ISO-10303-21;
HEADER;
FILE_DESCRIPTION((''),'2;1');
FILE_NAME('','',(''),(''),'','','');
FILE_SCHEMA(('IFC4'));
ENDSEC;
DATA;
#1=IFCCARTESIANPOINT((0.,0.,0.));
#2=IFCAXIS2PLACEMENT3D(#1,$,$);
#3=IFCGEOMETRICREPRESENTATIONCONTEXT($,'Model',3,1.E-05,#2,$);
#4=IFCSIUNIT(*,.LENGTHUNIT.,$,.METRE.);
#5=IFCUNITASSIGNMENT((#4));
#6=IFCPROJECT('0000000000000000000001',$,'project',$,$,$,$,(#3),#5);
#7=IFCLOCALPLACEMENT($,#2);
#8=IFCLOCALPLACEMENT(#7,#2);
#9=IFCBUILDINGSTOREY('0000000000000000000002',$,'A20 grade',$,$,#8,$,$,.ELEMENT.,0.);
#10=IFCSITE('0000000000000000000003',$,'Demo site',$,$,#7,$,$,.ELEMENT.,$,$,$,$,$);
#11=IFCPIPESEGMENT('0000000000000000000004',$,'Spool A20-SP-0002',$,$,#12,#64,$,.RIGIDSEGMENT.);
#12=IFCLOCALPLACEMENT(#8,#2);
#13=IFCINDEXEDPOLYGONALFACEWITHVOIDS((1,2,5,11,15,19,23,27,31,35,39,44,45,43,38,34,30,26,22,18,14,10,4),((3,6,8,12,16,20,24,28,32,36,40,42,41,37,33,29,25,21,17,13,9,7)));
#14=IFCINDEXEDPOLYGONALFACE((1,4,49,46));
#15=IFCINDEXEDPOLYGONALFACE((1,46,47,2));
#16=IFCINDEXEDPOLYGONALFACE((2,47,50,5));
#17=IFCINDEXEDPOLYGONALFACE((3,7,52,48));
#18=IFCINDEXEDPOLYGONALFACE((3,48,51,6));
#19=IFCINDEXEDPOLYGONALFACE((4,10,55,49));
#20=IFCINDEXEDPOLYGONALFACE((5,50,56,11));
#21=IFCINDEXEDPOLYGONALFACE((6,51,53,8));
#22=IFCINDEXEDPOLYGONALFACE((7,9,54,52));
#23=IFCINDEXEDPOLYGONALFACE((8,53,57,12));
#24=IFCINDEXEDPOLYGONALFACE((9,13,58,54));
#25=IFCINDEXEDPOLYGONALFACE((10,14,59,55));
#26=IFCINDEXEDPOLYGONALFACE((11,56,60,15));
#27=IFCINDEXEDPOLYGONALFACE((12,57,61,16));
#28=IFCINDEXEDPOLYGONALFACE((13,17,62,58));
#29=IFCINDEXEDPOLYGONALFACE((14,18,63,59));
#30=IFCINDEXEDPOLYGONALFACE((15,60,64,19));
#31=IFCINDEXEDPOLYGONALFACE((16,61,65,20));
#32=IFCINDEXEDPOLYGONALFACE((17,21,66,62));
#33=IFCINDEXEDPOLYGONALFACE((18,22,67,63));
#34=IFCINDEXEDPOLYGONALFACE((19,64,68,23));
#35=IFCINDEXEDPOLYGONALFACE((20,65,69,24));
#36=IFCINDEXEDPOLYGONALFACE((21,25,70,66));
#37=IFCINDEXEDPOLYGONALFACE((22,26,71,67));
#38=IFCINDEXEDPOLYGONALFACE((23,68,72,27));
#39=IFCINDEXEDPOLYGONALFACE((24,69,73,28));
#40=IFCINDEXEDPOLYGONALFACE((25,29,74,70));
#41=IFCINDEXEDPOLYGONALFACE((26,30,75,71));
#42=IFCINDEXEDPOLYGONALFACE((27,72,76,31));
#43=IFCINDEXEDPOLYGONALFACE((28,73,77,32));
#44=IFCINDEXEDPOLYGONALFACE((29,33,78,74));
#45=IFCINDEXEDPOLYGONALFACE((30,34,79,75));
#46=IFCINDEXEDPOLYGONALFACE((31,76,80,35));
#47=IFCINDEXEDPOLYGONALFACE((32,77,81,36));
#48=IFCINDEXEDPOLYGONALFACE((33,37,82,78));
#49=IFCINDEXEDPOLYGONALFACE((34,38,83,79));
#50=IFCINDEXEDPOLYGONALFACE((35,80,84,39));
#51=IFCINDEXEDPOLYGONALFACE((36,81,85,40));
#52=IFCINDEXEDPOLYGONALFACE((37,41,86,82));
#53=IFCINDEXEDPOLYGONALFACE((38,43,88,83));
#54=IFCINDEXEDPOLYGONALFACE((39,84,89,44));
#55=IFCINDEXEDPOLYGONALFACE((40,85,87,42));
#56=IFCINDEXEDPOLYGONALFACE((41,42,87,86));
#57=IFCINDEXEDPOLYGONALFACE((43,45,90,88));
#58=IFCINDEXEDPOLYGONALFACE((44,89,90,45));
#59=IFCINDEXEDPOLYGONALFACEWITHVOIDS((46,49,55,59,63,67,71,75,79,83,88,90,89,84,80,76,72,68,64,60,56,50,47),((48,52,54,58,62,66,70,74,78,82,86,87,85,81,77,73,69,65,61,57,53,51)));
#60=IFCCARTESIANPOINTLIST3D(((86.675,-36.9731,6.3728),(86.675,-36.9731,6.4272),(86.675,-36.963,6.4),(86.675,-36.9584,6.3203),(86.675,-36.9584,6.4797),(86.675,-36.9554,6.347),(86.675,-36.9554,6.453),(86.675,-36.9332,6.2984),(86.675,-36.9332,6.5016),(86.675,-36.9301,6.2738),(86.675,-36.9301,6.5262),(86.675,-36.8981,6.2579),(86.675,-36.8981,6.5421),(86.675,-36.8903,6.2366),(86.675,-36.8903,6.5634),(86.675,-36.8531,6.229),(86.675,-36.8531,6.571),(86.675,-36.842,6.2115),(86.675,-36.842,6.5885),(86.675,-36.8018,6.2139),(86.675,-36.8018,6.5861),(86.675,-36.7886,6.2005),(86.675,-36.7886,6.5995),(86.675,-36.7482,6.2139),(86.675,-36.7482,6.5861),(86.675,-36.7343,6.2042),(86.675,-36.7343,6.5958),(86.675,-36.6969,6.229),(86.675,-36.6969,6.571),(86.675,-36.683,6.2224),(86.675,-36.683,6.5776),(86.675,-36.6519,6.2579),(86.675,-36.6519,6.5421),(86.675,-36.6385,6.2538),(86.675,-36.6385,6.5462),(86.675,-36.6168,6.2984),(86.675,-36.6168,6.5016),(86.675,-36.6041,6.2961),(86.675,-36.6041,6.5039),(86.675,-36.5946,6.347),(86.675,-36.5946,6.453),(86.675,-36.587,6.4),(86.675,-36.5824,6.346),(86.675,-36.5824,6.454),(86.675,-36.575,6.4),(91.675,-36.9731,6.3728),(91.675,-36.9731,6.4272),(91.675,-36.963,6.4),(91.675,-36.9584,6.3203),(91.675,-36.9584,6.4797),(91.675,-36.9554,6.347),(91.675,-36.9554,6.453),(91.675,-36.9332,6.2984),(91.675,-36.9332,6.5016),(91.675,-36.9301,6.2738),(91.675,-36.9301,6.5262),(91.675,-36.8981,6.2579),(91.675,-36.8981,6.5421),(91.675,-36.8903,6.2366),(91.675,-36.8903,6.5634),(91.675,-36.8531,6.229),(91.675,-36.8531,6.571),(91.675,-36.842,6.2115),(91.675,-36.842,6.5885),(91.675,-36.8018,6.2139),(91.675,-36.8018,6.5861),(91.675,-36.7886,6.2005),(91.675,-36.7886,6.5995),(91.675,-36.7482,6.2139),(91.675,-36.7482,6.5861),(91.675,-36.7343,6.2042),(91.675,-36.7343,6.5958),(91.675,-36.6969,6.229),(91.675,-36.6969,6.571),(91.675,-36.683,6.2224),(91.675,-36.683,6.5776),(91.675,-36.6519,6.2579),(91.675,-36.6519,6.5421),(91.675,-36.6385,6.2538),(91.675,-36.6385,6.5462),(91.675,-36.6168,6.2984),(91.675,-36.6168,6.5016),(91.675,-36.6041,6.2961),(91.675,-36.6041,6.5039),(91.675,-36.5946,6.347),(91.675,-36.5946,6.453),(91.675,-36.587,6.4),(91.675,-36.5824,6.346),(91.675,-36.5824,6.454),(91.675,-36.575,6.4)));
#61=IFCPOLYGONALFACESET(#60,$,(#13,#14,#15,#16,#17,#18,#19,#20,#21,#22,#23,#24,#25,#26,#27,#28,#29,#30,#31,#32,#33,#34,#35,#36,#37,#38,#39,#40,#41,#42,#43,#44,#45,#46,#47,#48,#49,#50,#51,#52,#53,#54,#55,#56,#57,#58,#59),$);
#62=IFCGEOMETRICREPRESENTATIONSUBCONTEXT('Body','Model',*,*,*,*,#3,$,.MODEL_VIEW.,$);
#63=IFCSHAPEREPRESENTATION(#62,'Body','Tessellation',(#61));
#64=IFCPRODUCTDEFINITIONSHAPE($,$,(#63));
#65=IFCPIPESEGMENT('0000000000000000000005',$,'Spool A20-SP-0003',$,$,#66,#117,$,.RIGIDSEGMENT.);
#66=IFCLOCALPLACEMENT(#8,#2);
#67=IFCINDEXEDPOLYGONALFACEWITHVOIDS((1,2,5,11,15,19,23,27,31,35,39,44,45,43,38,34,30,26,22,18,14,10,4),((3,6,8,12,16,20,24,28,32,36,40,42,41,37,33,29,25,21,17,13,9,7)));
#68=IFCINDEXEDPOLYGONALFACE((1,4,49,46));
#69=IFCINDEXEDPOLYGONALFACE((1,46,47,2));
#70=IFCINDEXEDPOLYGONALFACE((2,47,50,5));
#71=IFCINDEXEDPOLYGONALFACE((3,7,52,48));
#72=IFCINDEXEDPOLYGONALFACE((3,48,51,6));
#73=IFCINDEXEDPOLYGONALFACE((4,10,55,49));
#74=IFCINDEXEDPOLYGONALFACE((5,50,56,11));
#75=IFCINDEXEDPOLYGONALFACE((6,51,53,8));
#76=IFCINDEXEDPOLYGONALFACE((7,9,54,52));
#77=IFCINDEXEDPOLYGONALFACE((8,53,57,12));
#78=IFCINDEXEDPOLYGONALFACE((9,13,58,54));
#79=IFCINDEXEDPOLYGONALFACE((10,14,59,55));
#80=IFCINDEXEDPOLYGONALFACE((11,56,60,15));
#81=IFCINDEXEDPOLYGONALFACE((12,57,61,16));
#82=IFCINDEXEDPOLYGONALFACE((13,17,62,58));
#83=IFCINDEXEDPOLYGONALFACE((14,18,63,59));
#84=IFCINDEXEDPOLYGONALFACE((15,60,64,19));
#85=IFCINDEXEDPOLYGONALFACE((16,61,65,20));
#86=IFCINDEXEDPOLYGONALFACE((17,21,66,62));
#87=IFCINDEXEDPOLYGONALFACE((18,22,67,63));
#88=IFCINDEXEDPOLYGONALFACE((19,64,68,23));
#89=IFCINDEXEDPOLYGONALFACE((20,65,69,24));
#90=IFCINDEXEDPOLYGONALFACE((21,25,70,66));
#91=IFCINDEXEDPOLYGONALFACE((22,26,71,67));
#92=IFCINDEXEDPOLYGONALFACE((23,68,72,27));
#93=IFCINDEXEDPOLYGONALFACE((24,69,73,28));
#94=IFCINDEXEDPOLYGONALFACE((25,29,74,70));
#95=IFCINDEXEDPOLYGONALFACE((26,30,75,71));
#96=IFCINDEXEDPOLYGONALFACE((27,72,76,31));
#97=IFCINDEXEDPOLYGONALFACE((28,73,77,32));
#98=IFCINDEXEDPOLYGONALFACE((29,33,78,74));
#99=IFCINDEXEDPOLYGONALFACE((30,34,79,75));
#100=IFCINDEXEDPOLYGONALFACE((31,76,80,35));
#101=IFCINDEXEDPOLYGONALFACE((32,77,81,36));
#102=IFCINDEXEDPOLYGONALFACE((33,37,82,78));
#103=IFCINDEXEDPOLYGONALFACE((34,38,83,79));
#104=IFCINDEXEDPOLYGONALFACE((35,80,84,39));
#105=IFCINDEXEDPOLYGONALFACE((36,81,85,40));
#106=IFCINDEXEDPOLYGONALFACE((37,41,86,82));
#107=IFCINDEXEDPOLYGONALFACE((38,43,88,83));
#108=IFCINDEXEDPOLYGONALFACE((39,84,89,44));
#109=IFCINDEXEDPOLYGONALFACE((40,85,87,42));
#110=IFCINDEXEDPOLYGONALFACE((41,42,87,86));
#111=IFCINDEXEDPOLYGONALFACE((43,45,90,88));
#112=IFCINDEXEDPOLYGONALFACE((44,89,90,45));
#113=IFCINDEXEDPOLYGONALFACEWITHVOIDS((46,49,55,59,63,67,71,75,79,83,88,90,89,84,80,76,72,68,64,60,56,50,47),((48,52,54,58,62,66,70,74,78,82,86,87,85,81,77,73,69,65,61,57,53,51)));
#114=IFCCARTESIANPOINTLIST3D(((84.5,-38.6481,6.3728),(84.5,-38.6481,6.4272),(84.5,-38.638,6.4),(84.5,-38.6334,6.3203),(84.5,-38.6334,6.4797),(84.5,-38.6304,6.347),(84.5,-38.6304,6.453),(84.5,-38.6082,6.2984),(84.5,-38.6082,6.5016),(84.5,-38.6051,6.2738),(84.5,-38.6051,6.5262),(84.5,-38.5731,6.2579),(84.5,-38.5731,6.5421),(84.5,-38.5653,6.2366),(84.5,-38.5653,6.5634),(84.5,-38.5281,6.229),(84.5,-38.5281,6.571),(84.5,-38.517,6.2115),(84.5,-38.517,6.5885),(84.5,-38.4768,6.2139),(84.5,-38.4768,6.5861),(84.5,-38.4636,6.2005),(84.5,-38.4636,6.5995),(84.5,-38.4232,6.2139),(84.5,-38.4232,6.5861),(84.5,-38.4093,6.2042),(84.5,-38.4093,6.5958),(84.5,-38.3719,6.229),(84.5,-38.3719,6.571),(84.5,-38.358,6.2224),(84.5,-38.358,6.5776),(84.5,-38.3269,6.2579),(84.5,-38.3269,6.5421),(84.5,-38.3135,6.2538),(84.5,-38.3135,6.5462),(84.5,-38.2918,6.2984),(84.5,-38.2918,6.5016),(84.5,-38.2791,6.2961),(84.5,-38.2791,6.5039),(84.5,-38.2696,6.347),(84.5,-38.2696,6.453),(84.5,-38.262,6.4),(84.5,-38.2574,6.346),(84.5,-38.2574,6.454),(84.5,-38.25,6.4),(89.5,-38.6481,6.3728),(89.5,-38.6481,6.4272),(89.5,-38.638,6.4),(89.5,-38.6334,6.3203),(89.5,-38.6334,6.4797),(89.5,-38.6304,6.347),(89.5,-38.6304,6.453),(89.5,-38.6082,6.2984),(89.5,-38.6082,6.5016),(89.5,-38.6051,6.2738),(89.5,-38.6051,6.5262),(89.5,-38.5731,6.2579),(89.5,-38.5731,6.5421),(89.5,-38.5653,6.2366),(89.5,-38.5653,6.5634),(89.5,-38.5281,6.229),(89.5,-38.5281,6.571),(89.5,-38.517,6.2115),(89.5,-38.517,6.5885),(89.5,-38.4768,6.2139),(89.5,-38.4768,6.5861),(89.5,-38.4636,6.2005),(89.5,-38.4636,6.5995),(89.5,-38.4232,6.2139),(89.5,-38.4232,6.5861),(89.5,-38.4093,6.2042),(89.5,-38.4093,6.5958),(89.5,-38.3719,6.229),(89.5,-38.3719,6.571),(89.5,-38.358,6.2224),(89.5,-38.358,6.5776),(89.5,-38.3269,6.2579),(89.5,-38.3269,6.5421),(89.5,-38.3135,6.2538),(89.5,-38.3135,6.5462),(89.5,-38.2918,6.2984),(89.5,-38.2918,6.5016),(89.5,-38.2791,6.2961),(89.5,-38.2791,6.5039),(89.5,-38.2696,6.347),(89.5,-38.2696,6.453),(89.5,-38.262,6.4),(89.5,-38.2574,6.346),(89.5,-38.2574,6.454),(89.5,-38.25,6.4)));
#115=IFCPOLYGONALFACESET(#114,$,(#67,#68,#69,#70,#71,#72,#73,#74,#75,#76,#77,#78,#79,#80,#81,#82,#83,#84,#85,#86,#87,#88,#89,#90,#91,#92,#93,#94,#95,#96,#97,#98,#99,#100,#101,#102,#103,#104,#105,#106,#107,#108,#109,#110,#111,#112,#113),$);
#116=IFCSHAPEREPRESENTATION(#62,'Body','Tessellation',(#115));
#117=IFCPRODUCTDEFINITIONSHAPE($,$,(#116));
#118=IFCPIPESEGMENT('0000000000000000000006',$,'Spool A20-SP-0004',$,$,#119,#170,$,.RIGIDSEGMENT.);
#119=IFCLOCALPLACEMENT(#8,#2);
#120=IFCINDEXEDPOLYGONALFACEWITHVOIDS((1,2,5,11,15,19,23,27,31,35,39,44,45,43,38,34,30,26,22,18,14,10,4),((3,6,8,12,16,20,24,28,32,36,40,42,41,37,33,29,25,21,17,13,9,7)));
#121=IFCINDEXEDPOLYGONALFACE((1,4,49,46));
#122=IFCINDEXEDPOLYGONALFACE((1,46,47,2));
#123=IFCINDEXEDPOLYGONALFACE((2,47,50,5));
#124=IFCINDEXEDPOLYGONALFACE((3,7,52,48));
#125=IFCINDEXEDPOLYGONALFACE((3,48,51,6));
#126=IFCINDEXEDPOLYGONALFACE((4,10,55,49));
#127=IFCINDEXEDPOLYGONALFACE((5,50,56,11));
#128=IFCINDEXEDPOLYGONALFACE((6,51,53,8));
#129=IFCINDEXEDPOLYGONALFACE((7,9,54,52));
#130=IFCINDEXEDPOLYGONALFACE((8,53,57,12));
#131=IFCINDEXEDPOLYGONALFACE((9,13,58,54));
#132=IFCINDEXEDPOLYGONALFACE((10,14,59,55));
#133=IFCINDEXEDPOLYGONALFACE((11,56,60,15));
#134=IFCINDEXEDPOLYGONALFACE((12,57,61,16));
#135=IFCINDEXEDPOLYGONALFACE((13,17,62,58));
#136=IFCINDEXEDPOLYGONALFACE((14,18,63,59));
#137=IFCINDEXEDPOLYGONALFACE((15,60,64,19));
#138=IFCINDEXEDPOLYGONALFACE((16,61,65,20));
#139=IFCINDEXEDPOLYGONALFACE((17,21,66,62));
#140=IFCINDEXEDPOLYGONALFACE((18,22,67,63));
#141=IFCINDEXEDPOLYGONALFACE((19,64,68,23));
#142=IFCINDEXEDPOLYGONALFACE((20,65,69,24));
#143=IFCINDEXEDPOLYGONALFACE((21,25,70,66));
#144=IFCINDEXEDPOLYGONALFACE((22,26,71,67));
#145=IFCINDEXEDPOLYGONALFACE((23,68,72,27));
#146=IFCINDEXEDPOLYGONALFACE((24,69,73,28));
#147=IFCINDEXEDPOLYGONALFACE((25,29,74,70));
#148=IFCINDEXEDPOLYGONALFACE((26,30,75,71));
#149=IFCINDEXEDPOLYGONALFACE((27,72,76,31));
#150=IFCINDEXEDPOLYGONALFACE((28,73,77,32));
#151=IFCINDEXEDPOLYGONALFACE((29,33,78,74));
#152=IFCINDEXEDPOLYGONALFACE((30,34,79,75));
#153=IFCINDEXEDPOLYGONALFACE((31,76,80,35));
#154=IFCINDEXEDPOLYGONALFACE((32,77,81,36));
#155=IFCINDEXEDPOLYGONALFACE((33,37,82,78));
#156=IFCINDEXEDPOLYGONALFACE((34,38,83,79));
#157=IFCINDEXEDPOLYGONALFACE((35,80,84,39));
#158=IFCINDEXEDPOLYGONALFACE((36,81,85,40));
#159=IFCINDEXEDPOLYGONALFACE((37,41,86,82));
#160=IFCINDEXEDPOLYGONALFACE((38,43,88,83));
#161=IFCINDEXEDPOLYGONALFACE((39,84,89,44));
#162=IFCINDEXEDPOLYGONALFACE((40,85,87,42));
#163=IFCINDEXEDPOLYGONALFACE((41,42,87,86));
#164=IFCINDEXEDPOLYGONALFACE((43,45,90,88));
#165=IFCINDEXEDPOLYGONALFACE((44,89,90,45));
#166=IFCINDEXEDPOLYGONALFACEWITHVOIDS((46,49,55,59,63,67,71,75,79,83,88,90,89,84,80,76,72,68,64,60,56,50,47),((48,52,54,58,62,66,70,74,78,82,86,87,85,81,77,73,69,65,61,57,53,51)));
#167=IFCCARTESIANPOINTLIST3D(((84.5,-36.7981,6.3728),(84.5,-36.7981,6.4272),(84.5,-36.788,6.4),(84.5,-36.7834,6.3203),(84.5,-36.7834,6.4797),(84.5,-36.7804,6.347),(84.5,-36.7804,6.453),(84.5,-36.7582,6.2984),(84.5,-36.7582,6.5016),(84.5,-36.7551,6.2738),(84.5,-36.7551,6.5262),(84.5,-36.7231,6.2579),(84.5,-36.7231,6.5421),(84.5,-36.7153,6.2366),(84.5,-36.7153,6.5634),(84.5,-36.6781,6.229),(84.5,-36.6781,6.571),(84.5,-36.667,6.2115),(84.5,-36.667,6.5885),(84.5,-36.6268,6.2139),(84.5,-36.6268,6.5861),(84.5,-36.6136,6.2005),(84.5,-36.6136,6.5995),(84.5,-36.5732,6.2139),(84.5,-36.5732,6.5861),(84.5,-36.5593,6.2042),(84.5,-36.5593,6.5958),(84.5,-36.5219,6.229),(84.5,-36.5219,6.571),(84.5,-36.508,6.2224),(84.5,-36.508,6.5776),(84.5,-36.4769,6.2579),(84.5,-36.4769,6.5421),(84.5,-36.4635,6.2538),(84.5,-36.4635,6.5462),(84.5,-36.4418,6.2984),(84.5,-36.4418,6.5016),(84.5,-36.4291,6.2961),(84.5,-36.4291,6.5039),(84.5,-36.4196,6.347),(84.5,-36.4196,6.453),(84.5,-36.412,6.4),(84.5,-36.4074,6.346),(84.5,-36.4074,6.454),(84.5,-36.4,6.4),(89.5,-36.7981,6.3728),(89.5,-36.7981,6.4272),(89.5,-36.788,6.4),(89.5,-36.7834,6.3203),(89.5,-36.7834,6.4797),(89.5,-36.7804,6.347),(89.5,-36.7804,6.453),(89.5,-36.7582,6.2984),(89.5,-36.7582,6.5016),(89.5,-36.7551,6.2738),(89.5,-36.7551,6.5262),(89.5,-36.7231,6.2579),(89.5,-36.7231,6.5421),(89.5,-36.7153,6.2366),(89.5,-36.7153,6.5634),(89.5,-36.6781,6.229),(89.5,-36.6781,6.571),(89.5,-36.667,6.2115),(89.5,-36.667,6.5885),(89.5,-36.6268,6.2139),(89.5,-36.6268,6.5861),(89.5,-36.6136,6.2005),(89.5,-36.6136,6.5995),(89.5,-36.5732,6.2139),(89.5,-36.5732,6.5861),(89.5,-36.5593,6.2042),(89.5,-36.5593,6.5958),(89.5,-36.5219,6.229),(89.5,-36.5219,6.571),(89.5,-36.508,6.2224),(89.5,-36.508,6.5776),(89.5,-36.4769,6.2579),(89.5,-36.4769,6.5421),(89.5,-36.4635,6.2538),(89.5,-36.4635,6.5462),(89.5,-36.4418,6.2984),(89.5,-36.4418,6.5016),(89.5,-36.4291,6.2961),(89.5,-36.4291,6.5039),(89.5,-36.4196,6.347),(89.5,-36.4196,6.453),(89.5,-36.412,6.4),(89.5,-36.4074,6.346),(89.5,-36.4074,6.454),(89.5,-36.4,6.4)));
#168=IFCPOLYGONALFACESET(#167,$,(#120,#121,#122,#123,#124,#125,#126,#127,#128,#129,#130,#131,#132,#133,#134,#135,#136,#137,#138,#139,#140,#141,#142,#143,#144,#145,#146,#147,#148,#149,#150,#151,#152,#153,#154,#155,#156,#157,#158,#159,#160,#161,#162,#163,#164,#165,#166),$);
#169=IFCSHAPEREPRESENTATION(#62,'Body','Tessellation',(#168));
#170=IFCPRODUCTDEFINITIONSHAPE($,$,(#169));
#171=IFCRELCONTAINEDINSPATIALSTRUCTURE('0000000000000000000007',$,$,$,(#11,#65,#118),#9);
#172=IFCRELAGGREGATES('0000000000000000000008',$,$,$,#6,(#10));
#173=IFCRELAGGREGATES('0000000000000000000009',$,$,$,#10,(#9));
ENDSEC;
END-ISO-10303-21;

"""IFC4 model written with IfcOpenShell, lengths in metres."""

from ifc_helpers import new_model, si_unit, frame, origin, place, context, subcontext, project, spatial, hollow_circle, extrude, element, save


model = new_model("IFC4")

# Units and contexts
model_context = context("Model", 3, precision=1e-05, world=origin())
body_context = subcontext(model_context, "Body", "Model", "MODEL_VIEW")
ifc_project = project(units=[si_unit("LENGTHUNIT", "METRE")], contexts=[model_context])

# Site, storey
site_placement = place(None, origin())
site = spatial("IfcSite", under=ifc_project, at=site_placement, Name="Demo site", CompositionType="ELEMENT")
storey_placement = place(site_placement, origin())
storey = spatial("IfcBuildingStorey", under=site, at=storey_placement, Name="A20 grade", CompositionType="ELEMENT", Elevation=0.0)

# Pipe segments
for number, where, name in (
    (1, (86.675, -36.775, 6.4), "Spool A20-SP-0002"),
    (2, (84.5, -38.45, 6.4), "Spool A20-SP-0003"),
    (3, (84.5, -36.6, 6.4), "Spool A20-SP-0004"),
):
    element("IfcPipeSegment", number, at=place(storey_placement, frame(where)), inside=storey, Name=name, PredefinedType="RIGIDSEGMENT", context=body_context, shape_type="SweptSolid", body=[
        extrude(hollow_circle(Radius=0.2, WallThickness=0.012), frame((0.0, 0.0, 0.0), z_axis=(1.0, 0.0, 0.0), x_axis=(0.0, 1.0, 0.0)), (0.0, 0.0, 1.0), 5.0),
    ])

save(model, "model.ifc")
